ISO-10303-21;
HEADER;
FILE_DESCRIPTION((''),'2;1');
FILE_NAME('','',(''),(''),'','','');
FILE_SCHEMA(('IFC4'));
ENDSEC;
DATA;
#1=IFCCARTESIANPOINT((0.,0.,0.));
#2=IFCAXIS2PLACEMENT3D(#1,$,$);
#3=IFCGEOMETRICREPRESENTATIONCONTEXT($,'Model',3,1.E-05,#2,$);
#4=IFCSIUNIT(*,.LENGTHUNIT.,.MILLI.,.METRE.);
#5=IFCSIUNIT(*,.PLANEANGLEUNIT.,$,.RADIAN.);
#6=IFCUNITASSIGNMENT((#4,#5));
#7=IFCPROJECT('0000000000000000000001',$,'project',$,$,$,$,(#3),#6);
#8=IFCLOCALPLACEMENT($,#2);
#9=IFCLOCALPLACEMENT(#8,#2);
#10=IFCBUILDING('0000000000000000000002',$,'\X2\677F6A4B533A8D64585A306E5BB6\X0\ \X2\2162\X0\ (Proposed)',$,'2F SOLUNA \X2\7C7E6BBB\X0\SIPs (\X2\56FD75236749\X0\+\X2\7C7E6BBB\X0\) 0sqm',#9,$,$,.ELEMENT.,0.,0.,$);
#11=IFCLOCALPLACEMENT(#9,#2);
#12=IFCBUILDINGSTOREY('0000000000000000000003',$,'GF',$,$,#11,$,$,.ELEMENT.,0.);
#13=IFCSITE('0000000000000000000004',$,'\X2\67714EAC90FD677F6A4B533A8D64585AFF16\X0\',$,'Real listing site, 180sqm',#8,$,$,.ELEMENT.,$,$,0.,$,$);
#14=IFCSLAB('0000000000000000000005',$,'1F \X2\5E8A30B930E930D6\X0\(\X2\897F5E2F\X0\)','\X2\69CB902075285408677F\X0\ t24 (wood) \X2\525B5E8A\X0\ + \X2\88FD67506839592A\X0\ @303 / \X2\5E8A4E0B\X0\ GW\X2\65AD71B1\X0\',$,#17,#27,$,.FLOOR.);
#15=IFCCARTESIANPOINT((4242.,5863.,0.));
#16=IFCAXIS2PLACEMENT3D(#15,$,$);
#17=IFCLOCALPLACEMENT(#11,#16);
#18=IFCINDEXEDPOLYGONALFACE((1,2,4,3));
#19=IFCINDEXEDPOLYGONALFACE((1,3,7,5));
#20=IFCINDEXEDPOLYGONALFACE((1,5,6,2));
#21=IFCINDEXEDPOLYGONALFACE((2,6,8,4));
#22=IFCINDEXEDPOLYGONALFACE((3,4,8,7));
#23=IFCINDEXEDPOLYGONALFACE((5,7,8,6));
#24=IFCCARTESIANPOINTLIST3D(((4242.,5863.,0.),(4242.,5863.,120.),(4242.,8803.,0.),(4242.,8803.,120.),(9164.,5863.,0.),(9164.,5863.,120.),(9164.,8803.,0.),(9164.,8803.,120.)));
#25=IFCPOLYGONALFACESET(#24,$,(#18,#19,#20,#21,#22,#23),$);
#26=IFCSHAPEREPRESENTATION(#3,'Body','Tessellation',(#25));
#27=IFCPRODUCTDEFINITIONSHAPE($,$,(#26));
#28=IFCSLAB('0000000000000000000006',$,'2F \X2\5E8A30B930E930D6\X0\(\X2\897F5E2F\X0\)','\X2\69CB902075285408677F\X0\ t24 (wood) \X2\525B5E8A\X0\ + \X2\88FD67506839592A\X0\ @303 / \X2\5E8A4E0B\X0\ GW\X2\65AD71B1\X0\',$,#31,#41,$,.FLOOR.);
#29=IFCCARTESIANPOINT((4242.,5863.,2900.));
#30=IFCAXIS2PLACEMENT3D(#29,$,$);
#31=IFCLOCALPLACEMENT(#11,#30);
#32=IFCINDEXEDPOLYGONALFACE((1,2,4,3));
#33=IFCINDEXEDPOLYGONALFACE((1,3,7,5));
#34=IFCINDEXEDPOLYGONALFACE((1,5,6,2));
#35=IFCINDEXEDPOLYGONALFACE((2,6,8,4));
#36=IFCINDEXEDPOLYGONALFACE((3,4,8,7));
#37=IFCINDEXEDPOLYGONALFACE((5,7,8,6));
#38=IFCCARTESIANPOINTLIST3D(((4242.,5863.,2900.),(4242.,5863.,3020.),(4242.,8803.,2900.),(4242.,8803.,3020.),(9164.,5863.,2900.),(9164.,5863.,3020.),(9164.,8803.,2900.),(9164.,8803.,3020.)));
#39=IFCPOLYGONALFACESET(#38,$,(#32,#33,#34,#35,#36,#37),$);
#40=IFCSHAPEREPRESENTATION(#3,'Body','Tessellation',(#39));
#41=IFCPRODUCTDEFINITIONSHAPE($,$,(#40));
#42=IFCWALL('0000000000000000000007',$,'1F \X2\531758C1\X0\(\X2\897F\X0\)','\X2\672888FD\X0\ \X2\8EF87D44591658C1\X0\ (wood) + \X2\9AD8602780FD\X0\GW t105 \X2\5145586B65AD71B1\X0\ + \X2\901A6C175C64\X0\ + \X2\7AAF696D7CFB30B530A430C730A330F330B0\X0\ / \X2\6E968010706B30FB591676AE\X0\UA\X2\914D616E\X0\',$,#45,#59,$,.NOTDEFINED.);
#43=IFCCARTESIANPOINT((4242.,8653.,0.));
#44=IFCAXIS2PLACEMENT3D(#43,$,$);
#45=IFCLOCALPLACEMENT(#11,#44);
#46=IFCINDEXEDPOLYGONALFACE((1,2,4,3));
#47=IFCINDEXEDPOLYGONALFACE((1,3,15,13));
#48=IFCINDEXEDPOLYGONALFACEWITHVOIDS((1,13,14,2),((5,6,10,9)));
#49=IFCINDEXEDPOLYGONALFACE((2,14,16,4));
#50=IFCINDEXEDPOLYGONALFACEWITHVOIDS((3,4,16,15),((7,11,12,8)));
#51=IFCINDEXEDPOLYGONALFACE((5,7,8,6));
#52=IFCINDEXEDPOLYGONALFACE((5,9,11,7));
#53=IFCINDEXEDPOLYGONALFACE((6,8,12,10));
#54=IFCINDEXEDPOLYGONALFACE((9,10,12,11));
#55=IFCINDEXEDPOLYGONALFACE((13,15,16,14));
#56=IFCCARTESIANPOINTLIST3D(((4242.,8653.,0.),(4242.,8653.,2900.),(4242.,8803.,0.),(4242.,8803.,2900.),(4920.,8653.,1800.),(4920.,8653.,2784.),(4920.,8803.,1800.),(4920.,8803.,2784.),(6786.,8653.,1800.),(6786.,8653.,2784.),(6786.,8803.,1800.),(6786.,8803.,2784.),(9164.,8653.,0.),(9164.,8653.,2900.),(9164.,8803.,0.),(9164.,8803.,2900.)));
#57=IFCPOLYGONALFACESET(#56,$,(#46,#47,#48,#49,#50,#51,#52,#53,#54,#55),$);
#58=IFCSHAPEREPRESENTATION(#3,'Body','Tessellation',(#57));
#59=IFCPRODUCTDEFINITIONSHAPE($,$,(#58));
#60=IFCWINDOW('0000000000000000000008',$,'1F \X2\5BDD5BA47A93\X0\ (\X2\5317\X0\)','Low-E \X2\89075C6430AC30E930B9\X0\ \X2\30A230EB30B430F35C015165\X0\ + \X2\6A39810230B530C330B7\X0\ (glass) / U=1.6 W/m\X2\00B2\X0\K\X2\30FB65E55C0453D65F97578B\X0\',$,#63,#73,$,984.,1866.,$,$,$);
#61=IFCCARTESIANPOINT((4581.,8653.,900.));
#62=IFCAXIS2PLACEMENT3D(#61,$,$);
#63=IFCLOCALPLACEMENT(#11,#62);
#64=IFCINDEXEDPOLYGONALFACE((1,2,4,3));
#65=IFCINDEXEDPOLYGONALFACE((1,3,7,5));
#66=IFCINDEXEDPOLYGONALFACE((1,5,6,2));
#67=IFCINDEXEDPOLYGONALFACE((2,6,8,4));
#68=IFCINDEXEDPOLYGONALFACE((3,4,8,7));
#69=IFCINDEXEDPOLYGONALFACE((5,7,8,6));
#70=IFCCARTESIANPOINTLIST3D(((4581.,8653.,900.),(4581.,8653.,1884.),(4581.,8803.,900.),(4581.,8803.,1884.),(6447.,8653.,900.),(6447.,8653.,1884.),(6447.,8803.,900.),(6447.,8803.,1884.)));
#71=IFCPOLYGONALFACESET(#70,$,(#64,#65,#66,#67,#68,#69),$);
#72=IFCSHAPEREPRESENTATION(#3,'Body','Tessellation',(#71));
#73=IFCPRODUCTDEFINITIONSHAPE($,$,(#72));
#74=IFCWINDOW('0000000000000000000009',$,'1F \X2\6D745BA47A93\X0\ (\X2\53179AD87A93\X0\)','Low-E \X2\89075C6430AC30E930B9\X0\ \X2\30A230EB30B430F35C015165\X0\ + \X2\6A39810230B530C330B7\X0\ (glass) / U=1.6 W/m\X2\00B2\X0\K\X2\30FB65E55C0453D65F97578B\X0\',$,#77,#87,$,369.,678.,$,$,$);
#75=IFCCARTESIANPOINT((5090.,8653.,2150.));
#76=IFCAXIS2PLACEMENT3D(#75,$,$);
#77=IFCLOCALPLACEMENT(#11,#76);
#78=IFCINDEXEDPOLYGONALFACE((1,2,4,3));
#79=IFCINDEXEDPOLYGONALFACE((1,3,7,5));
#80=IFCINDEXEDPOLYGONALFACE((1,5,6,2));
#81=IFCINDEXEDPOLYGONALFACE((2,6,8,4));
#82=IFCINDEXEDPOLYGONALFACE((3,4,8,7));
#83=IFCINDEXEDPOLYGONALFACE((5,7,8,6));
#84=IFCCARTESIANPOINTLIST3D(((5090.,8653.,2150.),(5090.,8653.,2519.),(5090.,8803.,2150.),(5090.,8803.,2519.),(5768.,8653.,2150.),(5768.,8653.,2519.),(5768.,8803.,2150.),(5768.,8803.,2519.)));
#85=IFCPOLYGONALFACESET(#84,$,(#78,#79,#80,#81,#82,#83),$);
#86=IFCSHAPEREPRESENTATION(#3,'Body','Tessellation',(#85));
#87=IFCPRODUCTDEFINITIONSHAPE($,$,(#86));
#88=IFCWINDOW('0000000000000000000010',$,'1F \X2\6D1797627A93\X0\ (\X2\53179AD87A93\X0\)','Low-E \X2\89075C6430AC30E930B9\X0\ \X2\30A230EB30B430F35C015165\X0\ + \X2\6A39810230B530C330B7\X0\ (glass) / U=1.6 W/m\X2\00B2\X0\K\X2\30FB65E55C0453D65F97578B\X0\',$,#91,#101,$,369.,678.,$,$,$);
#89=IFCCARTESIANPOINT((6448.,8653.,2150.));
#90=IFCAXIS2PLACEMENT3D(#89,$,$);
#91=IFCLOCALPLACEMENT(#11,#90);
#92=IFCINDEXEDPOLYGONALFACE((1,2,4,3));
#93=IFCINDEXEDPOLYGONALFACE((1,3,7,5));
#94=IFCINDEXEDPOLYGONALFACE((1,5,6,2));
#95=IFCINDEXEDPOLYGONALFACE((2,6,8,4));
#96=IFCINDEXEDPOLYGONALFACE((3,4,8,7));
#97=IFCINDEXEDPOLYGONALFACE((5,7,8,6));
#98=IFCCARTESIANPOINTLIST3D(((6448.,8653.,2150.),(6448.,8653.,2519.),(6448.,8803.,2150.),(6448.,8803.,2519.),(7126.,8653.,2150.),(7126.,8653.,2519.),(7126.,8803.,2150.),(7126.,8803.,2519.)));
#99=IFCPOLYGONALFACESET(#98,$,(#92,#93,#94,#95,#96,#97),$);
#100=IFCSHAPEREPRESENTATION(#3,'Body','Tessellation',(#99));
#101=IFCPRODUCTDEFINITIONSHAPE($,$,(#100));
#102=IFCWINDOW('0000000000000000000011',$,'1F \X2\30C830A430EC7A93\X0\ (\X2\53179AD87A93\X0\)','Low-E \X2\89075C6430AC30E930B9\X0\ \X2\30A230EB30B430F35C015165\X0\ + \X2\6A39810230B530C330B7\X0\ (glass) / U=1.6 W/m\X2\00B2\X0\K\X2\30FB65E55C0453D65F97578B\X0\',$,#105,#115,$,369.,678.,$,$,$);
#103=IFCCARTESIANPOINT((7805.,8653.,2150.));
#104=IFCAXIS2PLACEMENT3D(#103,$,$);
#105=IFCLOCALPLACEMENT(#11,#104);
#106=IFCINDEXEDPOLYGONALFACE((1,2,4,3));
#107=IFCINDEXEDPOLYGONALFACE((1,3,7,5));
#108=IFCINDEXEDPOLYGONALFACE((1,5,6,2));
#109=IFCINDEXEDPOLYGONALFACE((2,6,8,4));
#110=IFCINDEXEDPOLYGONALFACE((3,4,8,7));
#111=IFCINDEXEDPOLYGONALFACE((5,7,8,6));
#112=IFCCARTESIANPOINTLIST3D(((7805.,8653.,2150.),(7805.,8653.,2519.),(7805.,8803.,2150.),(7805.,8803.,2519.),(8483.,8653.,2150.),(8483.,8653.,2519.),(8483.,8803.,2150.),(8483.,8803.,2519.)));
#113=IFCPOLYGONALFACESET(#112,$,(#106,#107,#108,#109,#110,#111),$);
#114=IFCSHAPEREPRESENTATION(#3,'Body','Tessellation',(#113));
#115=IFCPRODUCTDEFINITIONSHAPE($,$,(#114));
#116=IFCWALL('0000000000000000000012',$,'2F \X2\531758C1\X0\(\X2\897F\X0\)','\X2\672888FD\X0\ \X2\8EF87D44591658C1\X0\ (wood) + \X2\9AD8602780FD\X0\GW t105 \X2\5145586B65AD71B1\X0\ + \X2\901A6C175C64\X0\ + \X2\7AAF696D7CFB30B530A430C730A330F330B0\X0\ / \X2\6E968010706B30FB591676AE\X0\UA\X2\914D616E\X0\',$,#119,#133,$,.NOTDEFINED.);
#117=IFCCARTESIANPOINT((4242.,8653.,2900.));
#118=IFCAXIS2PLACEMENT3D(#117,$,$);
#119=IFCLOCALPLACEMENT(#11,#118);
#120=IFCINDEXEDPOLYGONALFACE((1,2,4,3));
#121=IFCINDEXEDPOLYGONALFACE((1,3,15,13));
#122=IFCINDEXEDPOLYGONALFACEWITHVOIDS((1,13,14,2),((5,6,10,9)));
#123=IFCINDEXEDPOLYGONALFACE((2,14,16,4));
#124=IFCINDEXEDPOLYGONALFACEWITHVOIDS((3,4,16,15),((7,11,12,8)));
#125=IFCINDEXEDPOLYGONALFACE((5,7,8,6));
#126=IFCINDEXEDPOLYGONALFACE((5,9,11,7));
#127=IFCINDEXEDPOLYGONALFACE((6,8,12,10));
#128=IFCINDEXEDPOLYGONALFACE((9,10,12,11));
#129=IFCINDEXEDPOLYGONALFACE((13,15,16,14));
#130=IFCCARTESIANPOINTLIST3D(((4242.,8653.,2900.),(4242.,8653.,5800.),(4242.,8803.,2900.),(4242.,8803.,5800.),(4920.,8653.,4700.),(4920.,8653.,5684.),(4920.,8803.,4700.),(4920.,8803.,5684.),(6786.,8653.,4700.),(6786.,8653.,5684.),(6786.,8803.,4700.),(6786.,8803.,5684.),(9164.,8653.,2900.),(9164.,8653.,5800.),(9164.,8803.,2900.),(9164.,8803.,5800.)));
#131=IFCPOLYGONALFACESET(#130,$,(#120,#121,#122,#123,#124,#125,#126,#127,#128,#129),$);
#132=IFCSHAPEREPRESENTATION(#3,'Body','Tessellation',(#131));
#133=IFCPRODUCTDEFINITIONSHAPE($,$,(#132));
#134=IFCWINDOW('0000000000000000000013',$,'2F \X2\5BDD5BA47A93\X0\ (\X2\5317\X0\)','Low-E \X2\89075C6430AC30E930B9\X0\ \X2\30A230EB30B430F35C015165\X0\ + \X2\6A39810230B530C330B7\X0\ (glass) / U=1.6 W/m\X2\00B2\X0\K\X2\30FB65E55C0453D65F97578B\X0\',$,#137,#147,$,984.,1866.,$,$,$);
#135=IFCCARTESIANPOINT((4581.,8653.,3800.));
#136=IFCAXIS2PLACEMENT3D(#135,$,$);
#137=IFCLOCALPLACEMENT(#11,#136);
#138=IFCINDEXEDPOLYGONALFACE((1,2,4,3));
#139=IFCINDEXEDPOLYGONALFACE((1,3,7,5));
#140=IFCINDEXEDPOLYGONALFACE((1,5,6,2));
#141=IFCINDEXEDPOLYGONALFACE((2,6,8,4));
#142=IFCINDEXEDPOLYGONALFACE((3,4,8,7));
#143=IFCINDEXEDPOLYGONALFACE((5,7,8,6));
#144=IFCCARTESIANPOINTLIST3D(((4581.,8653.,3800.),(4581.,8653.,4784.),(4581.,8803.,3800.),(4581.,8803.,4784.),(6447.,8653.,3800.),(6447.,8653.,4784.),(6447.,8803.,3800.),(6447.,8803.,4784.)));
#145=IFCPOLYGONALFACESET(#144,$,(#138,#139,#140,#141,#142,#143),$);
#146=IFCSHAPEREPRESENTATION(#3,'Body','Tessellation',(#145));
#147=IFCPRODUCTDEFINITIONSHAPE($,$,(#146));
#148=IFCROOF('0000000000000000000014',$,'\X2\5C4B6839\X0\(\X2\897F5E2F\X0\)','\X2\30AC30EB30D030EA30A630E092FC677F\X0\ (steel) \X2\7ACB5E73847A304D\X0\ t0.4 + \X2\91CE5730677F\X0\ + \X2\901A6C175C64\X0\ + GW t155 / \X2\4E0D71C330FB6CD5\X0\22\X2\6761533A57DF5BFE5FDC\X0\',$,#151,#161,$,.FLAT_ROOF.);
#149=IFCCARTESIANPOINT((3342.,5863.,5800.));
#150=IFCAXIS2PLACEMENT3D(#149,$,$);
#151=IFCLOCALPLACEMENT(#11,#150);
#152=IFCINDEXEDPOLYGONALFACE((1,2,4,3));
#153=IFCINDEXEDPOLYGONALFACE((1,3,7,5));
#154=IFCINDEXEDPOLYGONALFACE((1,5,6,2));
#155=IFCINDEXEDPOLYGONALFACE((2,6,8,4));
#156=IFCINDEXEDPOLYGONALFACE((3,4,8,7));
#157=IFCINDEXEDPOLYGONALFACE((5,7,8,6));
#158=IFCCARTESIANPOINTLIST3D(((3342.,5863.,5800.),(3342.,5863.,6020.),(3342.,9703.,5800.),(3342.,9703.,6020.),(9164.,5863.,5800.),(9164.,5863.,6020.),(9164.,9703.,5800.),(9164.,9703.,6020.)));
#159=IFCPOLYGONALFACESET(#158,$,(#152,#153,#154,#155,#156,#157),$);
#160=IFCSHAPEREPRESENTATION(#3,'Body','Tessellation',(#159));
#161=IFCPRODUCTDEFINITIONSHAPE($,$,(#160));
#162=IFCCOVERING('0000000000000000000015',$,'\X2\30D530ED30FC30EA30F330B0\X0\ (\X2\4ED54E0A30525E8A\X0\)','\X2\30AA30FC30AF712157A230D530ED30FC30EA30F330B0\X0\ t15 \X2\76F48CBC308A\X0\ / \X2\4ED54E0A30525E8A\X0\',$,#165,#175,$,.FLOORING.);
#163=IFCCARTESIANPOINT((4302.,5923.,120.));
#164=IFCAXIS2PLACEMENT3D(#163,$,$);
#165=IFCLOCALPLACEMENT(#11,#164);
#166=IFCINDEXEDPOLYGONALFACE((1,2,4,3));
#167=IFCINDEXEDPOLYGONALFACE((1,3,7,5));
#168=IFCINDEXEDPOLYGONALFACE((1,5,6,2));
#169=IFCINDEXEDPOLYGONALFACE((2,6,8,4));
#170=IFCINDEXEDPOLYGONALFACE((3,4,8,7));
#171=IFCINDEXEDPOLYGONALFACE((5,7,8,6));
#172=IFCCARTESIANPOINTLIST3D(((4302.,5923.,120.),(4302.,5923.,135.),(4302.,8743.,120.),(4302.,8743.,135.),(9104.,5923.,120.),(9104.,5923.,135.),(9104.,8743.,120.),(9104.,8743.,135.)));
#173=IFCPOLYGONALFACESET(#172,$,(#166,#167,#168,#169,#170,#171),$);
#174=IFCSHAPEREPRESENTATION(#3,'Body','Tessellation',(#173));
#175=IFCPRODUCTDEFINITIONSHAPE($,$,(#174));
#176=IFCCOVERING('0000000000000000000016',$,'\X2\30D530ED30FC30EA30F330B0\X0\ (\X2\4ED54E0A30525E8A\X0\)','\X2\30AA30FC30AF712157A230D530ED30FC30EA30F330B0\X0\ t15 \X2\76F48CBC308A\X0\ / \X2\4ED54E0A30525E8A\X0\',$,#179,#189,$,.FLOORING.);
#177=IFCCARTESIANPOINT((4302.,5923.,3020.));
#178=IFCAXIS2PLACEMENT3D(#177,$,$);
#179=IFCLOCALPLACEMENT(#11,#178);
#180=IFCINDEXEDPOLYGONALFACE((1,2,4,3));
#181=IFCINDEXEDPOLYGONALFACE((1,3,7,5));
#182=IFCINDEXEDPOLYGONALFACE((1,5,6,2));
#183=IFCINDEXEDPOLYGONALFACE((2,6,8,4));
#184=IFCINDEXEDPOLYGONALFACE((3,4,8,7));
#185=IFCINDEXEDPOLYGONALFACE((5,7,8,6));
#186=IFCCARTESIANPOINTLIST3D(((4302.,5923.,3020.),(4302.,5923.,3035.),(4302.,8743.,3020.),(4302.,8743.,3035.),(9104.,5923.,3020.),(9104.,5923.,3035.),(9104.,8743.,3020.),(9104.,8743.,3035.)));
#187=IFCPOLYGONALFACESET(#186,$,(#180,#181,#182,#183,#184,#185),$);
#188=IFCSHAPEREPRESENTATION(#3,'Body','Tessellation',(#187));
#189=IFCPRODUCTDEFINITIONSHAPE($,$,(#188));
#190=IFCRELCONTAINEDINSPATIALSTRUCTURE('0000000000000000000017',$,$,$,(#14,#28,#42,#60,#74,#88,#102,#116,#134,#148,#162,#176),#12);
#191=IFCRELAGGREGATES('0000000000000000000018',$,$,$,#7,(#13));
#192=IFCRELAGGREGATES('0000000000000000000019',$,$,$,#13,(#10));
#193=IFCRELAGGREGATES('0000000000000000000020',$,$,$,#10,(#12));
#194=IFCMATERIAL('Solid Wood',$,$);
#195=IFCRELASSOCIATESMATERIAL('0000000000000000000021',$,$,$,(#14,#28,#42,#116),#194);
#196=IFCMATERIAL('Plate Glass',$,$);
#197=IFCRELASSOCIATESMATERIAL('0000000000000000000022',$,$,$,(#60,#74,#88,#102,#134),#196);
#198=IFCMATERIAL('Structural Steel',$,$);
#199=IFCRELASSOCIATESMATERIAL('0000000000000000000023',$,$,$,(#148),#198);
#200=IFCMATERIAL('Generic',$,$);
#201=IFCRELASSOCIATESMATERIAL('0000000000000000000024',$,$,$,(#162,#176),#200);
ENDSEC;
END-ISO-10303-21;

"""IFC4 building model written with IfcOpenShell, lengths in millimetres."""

from ifc_helpers import new_model, si_unit, frame, frame_2d, origin, place, context, project, spatial, rectangle, extrude, material, element, fill, save


model = new_model("IFC4")

# Units and contexts
model_context = context("Model", 3, precision=1e-05, world=origin())
ifc_project = project(units=[si_unit("LENGTHUNIT", "METRE", prefix="MILLI"), si_unit("PLANEANGLEUNIT", "RADIAN")], contexts=[model_context])

# Site, building, storey
site_placement = place(None, origin())
site = spatial("IfcSite", under=ifc_project, at=site_placement, Name="東京都板橋区赤塚６", ObjectType="Real listing site, 180sqm", CompositionType="ELEMENT", RefElevation=0.0)
building_placement = place(site_placement, origin())
building = spatial("IfcBuilding", under=site, at=building_placement, Name="板橋区赤塚の家 Ⅲ (Proposed)", ObjectType="2F SOLUNA 籾殻SIPs (国産杉+籾殻) 0sqm", CompositionType="ELEMENT", ElevationOfRefHeight=0.0, ElevationOfTerrain=0.0)
storey_placement = place(building_placement, origin())
storey = spatial("IfcBuildingStorey", under=building, at=storey_placement, Name="GF", CompositionType="ELEMENT", Elevation=0.0)

# Slabs
ifc_material_1 = material(Name="Solid Wood")
slab_1_placement = place(storey_placement, frame((4242.0, 5863.0, 0.0)))
element("IfcSlab", 1, at=slab_1_placement, inside=storey, material=ifc_material_1, Name="1F 床スラブ(西帯)", Description="構造用合板 t24 (wood) 剛床 + 製材根太 @303 / 床下 GW断熱", PredefinedType="FLOOR", context=model_context, shape_type="SweptSolid", body=[
    extrude(rectangle(XDim=4922.0, YDim=2940.0, at=frame_2d((2461.0, 1470.0))), frame((4242.0, 5863.0, 0.0)), (0.0, 0.0, 1.0), 120.0),
])
slab_2_placement = place(storey_placement, frame((4242.0, 5863.0, 2900.0)))
element("IfcSlab", 2, at=slab_2_placement, inside=storey, material=ifc_material_1, Name="2F 床スラブ(西帯)", Description="構造用合板 t24 (wood) 剛床 + 製材根太 @303 / 床下 GW断熱", PredefinedType="FLOOR", context=model_context, shape_type="SweptSolid", body=[
    extrude(rectangle(XDim=4922.0, YDim=2940.0, at=frame_2d((2461.0, 1470.0))), frame((4242.0, 5863.0, 2900.0)), (0.0, 0.0, 1.0), 120.0),
])

# Wall, openings, windows
wall_1_placement = place(storey_placement, frame((4242.0, 8653.0, 0.0)))
wall_1 = element("IfcWall", 3, at=wall_1_placement, inside=storey, material=ifc_material_1, Name="1F 北壁(西)", Description="木製 軸組外壁 (wood) + 高性能GW t105 充填断熱 + 通気層 + 窯業系サイディング / 準耐火・外皮UA配慮", PredefinedType="NOTDEFINED", context=model_context, shape_type="SweptSolid", body=[
    extrude(rectangle(XDim=4922.0, YDim=150.0, at=frame_2d((2461.0, 75.0))), frame((4242.0, 8653.0, 0.0)), (0.0, 0.0, 1.0), 2900.0),
])
opening_1_placement = place(storey_placement, frame((4581.0, 8653.0, 900.0)))
opening_1 = element("IfcOpeningElement", 4, at=opening_1_placement, cuts=wall_1, PredefinedType="NOTDEFINED", context=model_context, shape_type="SweptSolid", body=[
    extrude(rectangle(XDim=1866.0, YDim=150.0, at=frame_2d((933.0, 75.0))), frame((4581.0, 8653.0, 900.0)), (0.0, 0.0, 1.0), 984.0),
])
opening_2_placement = place(storey_placement, frame((5090.0, 8653.0, 2150.0)))
opening_2 = element("IfcOpeningElement", 5, at=opening_2_placement, cuts=wall_1, PredefinedType="NOTDEFINED", context=model_context, shape_type="SweptSolid", body=[
    extrude(rectangle(XDim=678.0, YDim=150.0, at=frame_2d((339.0, 75.0))), frame((5090.0, 8653.0, 2150.0)), (0.0, 0.0, 1.0), 369.0),
])
opening_3_placement = place(storey_placement, frame((6448.0, 8653.0, 2150.0)))
opening_3 = element("IfcOpeningElement", 6, at=opening_3_placement, cuts=wall_1, PredefinedType="NOTDEFINED", context=model_context, shape_type="SweptSolid", body=[
    extrude(rectangle(XDim=678.0, YDim=150.0, at=frame_2d((339.0, 75.0))), frame((6448.0, 8653.0, 2150.0)), (0.0, 0.0, 1.0), 369.0),
])
opening_4_placement = place(storey_placement, frame((7805.0, 8653.0, 2150.0)))
opening_4 = element("IfcOpeningElement", 7, at=opening_4_placement, cuts=wall_1, PredefinedType="NOTDEFINED", context=model_context, shape_type="SweptSolid", body=[
    extrude(rectangle(XDim=678.0, YDim=150.0, at=frame_2d((339.0, 75.0))), frame((7805.0, 8653.0, 2150.0)), (0.0, 0.0, 1.0), 369.0),
])
ifc_material_2 = material(Name="Plate Glass")
window_1_placement = place(storey_placement, frame((4581.0, 8653.0, 900.0)))
window_1 = element("IfcWindow", 8, at=window_1_placement, inside=storey, material=ifc_material_2, Name="1F 寝室窓 (北)", Description="Low-E 複層ガラス アルゴン封入 + 樹脂サッシ (glass) / U=1.6 W/m²K・日射取得型", OverallHeight=984.0, OverallWidth=1866.0, context=model_context, shape_type="SweptSolid", body=[
    extrude(rectangle(XDim=1866.0, YDim=150.0, at=frame_2d((933.0, 75.0))), frame((4581.0, 8653.0, 900.0)), (0.0, 0.0, 1.0), 984.0),
])
fill(opening_1, window_1)
window_2_placement = place(storey_placement, frame((5090.0, 8653.0, 2150.0)))
window_2 = element("IfcWindow", 9, at=window_2_placement, inside=storey, material=ifc_material_2, Name="1F 浴室窓 (北高窓)", Description="Low-E 複層ガラス アルゴン封入 + 樹脂サッシ (glass) / U=1.6 W/m²K・日射取得型", OverallHeight=369.0, OverallWidth=678.0, context=model_context, shape_type="SweptSolid", body=[
    extrude(rectangle(XDim=678.0, YDim=150.0, at=frame_2d((339.0, 75.0))), frame((5090.0, 8653.0, 2150.0)), (0.0, 0.0, 1.0), 369.0),
])
fill(opening_2, window_2)
window_3_placement = place(storey_placement, frame((6448.0, 8653.0, 2150.0)))
window_3 = element("IfcWindow", 10, at=window_3_placement, inside=storey, material=ifc_material_2, Name="1F 洗面窓 (北高窓)", Description="Low-E 複層ガラス アルゴン封入 + 樹脂サッシ (glass) / U=1.6 W/m²K・日射取得型", OverallHeight=369.0, OverallWidth=678.0, context=model_context, shape_type="SweptSolid", body=[
    extrude(rectangle(XDim=678.0, YDim=150.0, at=frame_2d((339.0, 75.0))), frame((6448.0, 8653.0, 2150.0)), (0.0, 0.0, 1.0), 369.0),
])
fill(opening_3, window_3)
window_4_placement = place(storey_placement, frame((7805.0, 8653.0, 2150.0)))
window_4 = element("IfcWindow", 11, at=window_4_placement, inside=storey, material=ifc_material_2, Name="1F トイレ窓 (北高窓)", Description="Low-E 複層ガラス アルゴン封入 + 樹脂サッシ (glass) / U=1.6 W/m²K・日射取得型", OverallHeight=369.0, OverallWidth=678.0, context=model_context, shape_type="SweptSolid", body=[
    extrude(rectangle(XDim=678.0, YDim=150.0, at=frame_2d((339.0, 75.0))), frame((7805.0, 8653.0, 2150.0)), (0.0, 0.0, 1.0), 369.0),
])
fill(opening_4, window_4)

# Wall, opening, window
wall_2_placement = place(storey_placement, frame((4242.0, 8653.0, 2900.0)))
wall_2 = element("IfcWall", 12, at=wall_2_placement, inside=storey, material=ifc_material_1, Name="2F 北壁(西)", Description="木製 軸組外壁 (wood) + 高性能GW t105 充填断熱 + 通気層 + 窯業系サイディング / 準耐火・外皮UA配慮", PredefinedType="NOTDEFINED", context=model_context, shape_type="SweptSolid", body=[
    extrude(rectangle(XDim=4922.0, YDim=150.0, at=frame_2d((2461.0, 75.0))), frame((4242.0, 8653.0, 2900.0)), (0.0, 0.0, 1.0), 2900.0),
])
opening_5_placement = place(storey_placement, frame((4581.0, 8653.0, 3800.0)))
opening_5 = element("IfcOpeningElement", 13, at=opening_5_placement, cuts=wall_2, PredefinedType="NOTDEFINED", context=model_context, shape_type="SweptSolid", body=[
    extrude(rectangle(XDim=1866.0, YDim=150.0, at=frame_2d((933.0, 75.0))), frame((4581.0, 8653.0, 3800.0)), (0.0, 0.0, 1.0), 984.0),
])
window_5_placement = place(storey_placement, frame((4581.0, 8653.0, 3800.0)))
window_5 = element("IfcWindow", 14, at=window_5_placement, inside=storey, material=ifc_material_2, Name="2F 寝室窓 (北)", Description="Low-E 複層ガラス アルゴン封入 + 樹脂サッシ (glass) / U=1.6 W/m²K・日射取得型", OverallHeight=984.0, OverallWidth=1866.0, context=model_context, shape_type="SweptSolid", body=[
    extrude(rectangle(XDim=1866.0, YDim=150.0, at=frame_2d((933.0, 75.0))), frame((4581.0, 8653.0, 3800.0)), (0.0, 0.0, 1.0), 984.0),
])
fill(opening_5, window_5)

# Roof
ifc_material_3 = material(Name="Structural Steel")
for number, where, name in (
    (15, (3342.0, 5863.0, 5800.0), "屋根(西帯)"),
):
    element("IfcRoof", number, at=place(storey_placement, frame(where)), inside=storey, material=ifc_material_3, Name=name, Description="ガルバリウム鋼板 (steel) 立平葺き t0.4 + 野地板 + 通気層 + GW t155 / 不燃・法22条区域対応", PredefinedType="FLAT_ROOF", context=model_context, shape_type="SweptSolid", body=[
        extrude(rectangle(XDim=5822.0, YDim=3840.0, at=frame_2d((2911.0, 1920.0))), frame((3342.0, 5863.0, 5800.0)), (0.0, 0.0, 1.0), 220.0),
    ])

# Coverings
ifc_material_4 = material(Name="Generic")
covering_1_placement = place(storey_placement, frame((4302.0, 5923.0, 120.0)))
element("IfcCovering", 16, at=covering_1_placement, inside=storey, material=ifc_material_4, Name="フローリング (仕上げ床)", Description="オーク無垢フローリング t15 直貼り / 仕上げ床", PredefinedType="FLOORING", context=model_context, shape_type="SweptSolid", body=[
    extrude(rectangle(XDim=4802.0, YDim=2820.0, at=frame_2d((2401.0, 1410.0))), frame((4302.0, 5923.0, 120.0)), (0.0, 0.0, 1.0), 15.0),
])
covering_2_placement = place(storey_placement, frame((4302.0, 5923.0, 3020.0)))
element("IfcCovering", 17, at=covering_2_placement, inside=storey, material=ifc_material_4, Name="フローリング (仕上げ床)", Description="オーク無垢フローリング t15 直貼り / 仕上げ床", PredefinedType="FLOORING", context=model_context, shape_type="SweptSolid", body=[
    extrude(rectangle(XDim=4802.0, YDim=2820.0, at=frame_2d((2401.0, 1410.0))), frame((4302.0, 5923.0, 3020.0)), (0.0, 0.0, 1.0), 15.0),
])

save(model, "model.ifc")
